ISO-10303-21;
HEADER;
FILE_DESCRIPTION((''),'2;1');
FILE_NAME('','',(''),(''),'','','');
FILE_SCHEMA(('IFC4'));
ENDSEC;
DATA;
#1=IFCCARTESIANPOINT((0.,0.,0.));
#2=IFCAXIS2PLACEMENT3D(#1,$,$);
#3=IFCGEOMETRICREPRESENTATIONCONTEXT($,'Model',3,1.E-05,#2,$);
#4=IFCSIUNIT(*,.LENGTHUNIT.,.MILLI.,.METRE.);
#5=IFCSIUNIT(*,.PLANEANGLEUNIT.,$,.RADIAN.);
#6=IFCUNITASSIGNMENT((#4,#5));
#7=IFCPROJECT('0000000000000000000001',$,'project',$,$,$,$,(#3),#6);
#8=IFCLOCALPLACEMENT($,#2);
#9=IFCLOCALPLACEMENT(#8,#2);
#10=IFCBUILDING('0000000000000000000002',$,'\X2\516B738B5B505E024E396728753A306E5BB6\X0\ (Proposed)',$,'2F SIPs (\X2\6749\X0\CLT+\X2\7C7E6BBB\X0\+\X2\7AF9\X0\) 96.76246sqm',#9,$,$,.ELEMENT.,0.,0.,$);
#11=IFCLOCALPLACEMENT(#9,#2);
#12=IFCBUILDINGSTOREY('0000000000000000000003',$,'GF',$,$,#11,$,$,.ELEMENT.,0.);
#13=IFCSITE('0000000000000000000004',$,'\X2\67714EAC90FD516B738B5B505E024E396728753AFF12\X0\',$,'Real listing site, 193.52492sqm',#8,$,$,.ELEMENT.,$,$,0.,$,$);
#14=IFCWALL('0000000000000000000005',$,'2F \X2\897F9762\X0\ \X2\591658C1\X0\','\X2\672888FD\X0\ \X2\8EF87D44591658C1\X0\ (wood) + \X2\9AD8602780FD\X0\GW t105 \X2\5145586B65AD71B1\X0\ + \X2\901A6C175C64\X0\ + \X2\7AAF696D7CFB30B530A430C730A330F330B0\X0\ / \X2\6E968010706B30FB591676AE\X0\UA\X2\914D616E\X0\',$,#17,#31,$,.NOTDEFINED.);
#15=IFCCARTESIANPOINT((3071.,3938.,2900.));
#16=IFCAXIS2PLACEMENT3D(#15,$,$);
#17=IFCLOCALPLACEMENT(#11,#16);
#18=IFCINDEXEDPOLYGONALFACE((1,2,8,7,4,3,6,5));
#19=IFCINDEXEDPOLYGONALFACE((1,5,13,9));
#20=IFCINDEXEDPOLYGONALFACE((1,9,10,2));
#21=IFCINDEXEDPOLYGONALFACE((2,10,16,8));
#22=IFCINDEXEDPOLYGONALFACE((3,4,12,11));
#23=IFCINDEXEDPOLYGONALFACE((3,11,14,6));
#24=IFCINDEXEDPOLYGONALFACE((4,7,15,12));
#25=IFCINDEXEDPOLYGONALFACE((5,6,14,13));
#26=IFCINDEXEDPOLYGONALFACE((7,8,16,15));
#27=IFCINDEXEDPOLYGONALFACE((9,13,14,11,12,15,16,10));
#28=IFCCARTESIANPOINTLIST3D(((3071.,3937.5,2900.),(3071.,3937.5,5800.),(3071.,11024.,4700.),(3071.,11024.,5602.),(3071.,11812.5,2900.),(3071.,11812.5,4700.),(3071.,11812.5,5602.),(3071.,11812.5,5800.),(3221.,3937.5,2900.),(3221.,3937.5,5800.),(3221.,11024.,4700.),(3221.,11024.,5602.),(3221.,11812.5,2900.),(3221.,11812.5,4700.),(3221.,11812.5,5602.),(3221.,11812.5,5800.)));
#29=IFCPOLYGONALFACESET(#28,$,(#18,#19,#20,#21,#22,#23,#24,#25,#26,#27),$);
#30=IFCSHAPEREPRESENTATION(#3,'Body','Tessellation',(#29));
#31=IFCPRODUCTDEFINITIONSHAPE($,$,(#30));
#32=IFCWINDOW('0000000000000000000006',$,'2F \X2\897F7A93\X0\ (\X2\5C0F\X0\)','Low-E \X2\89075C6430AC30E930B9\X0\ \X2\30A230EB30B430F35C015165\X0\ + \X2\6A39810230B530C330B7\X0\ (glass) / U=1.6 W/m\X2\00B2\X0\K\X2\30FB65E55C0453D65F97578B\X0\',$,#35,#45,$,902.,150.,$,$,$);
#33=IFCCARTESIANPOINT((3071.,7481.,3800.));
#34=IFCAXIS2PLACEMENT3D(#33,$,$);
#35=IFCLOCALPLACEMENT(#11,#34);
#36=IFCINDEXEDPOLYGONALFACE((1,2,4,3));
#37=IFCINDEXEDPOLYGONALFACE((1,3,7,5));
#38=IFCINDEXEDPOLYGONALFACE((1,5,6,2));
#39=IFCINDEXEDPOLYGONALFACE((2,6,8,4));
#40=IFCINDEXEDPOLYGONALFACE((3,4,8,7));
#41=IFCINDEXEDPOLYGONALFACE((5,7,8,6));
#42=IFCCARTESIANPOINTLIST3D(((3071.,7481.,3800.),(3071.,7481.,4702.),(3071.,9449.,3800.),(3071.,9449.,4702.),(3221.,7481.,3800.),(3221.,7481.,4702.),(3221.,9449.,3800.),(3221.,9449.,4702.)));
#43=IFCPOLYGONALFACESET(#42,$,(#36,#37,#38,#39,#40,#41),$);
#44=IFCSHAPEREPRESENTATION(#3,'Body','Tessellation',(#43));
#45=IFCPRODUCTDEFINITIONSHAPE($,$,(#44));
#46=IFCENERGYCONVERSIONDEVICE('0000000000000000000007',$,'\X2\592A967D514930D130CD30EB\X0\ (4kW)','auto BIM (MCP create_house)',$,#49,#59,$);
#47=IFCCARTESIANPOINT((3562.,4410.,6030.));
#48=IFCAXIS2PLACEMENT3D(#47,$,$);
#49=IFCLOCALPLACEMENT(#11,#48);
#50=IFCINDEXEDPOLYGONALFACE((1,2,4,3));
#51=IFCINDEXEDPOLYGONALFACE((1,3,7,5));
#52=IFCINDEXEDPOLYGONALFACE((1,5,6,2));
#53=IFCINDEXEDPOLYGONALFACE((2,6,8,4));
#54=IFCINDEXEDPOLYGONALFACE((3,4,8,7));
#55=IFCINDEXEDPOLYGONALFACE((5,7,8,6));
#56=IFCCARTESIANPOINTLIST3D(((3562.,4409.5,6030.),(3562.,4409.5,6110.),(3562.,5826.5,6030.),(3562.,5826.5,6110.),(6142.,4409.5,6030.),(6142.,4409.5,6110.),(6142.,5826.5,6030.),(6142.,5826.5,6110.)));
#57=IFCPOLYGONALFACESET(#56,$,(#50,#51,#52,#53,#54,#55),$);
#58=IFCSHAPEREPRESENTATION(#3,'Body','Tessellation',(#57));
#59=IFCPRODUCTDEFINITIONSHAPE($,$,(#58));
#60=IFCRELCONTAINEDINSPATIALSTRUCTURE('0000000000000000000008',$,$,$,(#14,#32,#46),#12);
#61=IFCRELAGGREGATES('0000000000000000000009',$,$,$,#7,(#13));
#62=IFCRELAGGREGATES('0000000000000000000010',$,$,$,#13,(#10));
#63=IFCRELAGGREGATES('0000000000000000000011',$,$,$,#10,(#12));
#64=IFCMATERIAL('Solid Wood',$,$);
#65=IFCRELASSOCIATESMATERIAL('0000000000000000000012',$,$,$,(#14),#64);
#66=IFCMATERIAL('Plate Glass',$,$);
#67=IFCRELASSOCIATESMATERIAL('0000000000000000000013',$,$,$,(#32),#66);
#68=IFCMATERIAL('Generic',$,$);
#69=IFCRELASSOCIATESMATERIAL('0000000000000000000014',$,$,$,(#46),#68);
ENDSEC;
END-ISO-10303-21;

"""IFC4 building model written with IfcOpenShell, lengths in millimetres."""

from ifc_helpers import new_model, si_unit, frame, frame_2d, origin, place, context, project, spatial, rectangle, extrude, material, element, fill, save


model = new_model("IFC4")

# Units and contexts
model_context = context("Model", 3, precision=1e-05, world=origin())
ifc_project = project(units=[si_unit("LENGTHUNIT", "METRE", prefix="MILLI"), si_unit("PLANEANGLEUNIT", "RADIAN")], contexts=[model_context])

# Site, building, storey
site_placement = place(None, origin())
site = spatial("IfcSite", under=ifc_project, at=site_placement, Name="東京都八王子市丹木町２", ObjectType="Real listing site, 193.52492sqm", CompositionType="ELEMENT", RefElevation=0.0)
building_placement = place(site_placement, origin())
building = spatial("IfcBuilding", under=site, at=building_placement, Name="八王子市丹木町の家 (Proposed)", ObjectType="2F SIPs (杉CLT+籾殻+竹) 96.76246sqm", CompositionType="ELEMENT", ElevationOfRefHeight=0.0, ElevationOfTerrain=0.0)
storey_placement = place(building_placement, origin())
storey = spatial("IfcBuildingStorey", under=building, at=storey_placement, Name="GF", CompositionType="ELEMENT", Elevation=0.0)

# Shared definitions
ifc_material_1 = material(Name="Solid Wood")

# Shared definitions
ifc_material_2 = material(Name="Plate Glass")

# Wall, opening, window
wall_1_placement = place(storey_placement, frame((3071.0, 3938.0, 2900.0)))
wall_1 = element("IfcWall", 1, at=wall_1_placement, inside=storey, material=ifc_material_1, Name="2F 西面 外壁", Description="木製 軸組外壁 (wood) + 高性能GW t105 充填断熱 + 通気層 + 窯業系サイディング / 準耐火・外皮UA配慮", PredefinedType="NOTDEFINED", context=model_context, shape_type="SweptSolid", body=[
    extrude(rectangle(XDim=150.0, YDim=7875.0, at=frame_2d((75.0, 3937.0))), frame((3071.0, 3938.0, 2900.0)), (0.0, 0.0, 1.0), 2900.0),
])
opening_1_placement = place(storey_placement, frame((3071.0, 7481.0, 3800.0)))
opening_1 = element("IfcOpeningElement", 2, at=opening_1_placement, cuts=wall_1, PredefinedType="NOTDEFINED", context=model_context, shape_type="SweptSolid", body=[
    extrude(rectangle(XDim=150.0, YDim=1968.0, at=frame_2d((75.0, 984.0))), frame((3071.0, 7481.0, 3800.0)), (0.0, 0.0, 1.0), 902.0),
])
window_1_placement = place(storey_placement, frame((3071.0, 7481.0, 3800.0)))
window_1 = element("IfcWindow", 3, at=window_1_placement, inside=storey, material=ifc_material_2, Name="2F 西窓 (小)", Description="Low-E 複層ガラス アルゴン封入 + 樹脂サッシ (glass) / U=1.6 W/m²K・日射取得型", OverallHeight=902.0, OverallWidth=150.0, context=model_context, shape_type="SweptSolid", body=[
    extrude(rectangle(XDim=150.0, YDim=1968.0, at=frame_2d((75.0, 984.0))), frame((3071.0, 7481.0, 3800.0)), (0.0, 0.0, 1.0), 902.0),
])
fill(opening_1, window_1)

# Shared definitions
ifc_material_3 = material(Name="Generic")

# Energy conversion device
energy_conversion_device_placement = place(storey_placement, frame((3562.0, 4410.0, 6030.0)))
element("IfcEnergyConversionDevice", 4, at=energy_conversion_device_placement, inside=storey, material=ifc_material_3, Name="太陽光パネル (4kW)", Description="auto BIM (MCP create_house)", context=model_context, shape_type="SweptSolid", body=[
    extrude(rectangle(XDim=2580.0, YDim=1417.0, at=frame_2d((1290.0, 708.0))), frame((3562.0, 4410.0, 6030.0)), (0.0, 0.0, 1.0), 80.0),
])

save(model, "model.ifc")
